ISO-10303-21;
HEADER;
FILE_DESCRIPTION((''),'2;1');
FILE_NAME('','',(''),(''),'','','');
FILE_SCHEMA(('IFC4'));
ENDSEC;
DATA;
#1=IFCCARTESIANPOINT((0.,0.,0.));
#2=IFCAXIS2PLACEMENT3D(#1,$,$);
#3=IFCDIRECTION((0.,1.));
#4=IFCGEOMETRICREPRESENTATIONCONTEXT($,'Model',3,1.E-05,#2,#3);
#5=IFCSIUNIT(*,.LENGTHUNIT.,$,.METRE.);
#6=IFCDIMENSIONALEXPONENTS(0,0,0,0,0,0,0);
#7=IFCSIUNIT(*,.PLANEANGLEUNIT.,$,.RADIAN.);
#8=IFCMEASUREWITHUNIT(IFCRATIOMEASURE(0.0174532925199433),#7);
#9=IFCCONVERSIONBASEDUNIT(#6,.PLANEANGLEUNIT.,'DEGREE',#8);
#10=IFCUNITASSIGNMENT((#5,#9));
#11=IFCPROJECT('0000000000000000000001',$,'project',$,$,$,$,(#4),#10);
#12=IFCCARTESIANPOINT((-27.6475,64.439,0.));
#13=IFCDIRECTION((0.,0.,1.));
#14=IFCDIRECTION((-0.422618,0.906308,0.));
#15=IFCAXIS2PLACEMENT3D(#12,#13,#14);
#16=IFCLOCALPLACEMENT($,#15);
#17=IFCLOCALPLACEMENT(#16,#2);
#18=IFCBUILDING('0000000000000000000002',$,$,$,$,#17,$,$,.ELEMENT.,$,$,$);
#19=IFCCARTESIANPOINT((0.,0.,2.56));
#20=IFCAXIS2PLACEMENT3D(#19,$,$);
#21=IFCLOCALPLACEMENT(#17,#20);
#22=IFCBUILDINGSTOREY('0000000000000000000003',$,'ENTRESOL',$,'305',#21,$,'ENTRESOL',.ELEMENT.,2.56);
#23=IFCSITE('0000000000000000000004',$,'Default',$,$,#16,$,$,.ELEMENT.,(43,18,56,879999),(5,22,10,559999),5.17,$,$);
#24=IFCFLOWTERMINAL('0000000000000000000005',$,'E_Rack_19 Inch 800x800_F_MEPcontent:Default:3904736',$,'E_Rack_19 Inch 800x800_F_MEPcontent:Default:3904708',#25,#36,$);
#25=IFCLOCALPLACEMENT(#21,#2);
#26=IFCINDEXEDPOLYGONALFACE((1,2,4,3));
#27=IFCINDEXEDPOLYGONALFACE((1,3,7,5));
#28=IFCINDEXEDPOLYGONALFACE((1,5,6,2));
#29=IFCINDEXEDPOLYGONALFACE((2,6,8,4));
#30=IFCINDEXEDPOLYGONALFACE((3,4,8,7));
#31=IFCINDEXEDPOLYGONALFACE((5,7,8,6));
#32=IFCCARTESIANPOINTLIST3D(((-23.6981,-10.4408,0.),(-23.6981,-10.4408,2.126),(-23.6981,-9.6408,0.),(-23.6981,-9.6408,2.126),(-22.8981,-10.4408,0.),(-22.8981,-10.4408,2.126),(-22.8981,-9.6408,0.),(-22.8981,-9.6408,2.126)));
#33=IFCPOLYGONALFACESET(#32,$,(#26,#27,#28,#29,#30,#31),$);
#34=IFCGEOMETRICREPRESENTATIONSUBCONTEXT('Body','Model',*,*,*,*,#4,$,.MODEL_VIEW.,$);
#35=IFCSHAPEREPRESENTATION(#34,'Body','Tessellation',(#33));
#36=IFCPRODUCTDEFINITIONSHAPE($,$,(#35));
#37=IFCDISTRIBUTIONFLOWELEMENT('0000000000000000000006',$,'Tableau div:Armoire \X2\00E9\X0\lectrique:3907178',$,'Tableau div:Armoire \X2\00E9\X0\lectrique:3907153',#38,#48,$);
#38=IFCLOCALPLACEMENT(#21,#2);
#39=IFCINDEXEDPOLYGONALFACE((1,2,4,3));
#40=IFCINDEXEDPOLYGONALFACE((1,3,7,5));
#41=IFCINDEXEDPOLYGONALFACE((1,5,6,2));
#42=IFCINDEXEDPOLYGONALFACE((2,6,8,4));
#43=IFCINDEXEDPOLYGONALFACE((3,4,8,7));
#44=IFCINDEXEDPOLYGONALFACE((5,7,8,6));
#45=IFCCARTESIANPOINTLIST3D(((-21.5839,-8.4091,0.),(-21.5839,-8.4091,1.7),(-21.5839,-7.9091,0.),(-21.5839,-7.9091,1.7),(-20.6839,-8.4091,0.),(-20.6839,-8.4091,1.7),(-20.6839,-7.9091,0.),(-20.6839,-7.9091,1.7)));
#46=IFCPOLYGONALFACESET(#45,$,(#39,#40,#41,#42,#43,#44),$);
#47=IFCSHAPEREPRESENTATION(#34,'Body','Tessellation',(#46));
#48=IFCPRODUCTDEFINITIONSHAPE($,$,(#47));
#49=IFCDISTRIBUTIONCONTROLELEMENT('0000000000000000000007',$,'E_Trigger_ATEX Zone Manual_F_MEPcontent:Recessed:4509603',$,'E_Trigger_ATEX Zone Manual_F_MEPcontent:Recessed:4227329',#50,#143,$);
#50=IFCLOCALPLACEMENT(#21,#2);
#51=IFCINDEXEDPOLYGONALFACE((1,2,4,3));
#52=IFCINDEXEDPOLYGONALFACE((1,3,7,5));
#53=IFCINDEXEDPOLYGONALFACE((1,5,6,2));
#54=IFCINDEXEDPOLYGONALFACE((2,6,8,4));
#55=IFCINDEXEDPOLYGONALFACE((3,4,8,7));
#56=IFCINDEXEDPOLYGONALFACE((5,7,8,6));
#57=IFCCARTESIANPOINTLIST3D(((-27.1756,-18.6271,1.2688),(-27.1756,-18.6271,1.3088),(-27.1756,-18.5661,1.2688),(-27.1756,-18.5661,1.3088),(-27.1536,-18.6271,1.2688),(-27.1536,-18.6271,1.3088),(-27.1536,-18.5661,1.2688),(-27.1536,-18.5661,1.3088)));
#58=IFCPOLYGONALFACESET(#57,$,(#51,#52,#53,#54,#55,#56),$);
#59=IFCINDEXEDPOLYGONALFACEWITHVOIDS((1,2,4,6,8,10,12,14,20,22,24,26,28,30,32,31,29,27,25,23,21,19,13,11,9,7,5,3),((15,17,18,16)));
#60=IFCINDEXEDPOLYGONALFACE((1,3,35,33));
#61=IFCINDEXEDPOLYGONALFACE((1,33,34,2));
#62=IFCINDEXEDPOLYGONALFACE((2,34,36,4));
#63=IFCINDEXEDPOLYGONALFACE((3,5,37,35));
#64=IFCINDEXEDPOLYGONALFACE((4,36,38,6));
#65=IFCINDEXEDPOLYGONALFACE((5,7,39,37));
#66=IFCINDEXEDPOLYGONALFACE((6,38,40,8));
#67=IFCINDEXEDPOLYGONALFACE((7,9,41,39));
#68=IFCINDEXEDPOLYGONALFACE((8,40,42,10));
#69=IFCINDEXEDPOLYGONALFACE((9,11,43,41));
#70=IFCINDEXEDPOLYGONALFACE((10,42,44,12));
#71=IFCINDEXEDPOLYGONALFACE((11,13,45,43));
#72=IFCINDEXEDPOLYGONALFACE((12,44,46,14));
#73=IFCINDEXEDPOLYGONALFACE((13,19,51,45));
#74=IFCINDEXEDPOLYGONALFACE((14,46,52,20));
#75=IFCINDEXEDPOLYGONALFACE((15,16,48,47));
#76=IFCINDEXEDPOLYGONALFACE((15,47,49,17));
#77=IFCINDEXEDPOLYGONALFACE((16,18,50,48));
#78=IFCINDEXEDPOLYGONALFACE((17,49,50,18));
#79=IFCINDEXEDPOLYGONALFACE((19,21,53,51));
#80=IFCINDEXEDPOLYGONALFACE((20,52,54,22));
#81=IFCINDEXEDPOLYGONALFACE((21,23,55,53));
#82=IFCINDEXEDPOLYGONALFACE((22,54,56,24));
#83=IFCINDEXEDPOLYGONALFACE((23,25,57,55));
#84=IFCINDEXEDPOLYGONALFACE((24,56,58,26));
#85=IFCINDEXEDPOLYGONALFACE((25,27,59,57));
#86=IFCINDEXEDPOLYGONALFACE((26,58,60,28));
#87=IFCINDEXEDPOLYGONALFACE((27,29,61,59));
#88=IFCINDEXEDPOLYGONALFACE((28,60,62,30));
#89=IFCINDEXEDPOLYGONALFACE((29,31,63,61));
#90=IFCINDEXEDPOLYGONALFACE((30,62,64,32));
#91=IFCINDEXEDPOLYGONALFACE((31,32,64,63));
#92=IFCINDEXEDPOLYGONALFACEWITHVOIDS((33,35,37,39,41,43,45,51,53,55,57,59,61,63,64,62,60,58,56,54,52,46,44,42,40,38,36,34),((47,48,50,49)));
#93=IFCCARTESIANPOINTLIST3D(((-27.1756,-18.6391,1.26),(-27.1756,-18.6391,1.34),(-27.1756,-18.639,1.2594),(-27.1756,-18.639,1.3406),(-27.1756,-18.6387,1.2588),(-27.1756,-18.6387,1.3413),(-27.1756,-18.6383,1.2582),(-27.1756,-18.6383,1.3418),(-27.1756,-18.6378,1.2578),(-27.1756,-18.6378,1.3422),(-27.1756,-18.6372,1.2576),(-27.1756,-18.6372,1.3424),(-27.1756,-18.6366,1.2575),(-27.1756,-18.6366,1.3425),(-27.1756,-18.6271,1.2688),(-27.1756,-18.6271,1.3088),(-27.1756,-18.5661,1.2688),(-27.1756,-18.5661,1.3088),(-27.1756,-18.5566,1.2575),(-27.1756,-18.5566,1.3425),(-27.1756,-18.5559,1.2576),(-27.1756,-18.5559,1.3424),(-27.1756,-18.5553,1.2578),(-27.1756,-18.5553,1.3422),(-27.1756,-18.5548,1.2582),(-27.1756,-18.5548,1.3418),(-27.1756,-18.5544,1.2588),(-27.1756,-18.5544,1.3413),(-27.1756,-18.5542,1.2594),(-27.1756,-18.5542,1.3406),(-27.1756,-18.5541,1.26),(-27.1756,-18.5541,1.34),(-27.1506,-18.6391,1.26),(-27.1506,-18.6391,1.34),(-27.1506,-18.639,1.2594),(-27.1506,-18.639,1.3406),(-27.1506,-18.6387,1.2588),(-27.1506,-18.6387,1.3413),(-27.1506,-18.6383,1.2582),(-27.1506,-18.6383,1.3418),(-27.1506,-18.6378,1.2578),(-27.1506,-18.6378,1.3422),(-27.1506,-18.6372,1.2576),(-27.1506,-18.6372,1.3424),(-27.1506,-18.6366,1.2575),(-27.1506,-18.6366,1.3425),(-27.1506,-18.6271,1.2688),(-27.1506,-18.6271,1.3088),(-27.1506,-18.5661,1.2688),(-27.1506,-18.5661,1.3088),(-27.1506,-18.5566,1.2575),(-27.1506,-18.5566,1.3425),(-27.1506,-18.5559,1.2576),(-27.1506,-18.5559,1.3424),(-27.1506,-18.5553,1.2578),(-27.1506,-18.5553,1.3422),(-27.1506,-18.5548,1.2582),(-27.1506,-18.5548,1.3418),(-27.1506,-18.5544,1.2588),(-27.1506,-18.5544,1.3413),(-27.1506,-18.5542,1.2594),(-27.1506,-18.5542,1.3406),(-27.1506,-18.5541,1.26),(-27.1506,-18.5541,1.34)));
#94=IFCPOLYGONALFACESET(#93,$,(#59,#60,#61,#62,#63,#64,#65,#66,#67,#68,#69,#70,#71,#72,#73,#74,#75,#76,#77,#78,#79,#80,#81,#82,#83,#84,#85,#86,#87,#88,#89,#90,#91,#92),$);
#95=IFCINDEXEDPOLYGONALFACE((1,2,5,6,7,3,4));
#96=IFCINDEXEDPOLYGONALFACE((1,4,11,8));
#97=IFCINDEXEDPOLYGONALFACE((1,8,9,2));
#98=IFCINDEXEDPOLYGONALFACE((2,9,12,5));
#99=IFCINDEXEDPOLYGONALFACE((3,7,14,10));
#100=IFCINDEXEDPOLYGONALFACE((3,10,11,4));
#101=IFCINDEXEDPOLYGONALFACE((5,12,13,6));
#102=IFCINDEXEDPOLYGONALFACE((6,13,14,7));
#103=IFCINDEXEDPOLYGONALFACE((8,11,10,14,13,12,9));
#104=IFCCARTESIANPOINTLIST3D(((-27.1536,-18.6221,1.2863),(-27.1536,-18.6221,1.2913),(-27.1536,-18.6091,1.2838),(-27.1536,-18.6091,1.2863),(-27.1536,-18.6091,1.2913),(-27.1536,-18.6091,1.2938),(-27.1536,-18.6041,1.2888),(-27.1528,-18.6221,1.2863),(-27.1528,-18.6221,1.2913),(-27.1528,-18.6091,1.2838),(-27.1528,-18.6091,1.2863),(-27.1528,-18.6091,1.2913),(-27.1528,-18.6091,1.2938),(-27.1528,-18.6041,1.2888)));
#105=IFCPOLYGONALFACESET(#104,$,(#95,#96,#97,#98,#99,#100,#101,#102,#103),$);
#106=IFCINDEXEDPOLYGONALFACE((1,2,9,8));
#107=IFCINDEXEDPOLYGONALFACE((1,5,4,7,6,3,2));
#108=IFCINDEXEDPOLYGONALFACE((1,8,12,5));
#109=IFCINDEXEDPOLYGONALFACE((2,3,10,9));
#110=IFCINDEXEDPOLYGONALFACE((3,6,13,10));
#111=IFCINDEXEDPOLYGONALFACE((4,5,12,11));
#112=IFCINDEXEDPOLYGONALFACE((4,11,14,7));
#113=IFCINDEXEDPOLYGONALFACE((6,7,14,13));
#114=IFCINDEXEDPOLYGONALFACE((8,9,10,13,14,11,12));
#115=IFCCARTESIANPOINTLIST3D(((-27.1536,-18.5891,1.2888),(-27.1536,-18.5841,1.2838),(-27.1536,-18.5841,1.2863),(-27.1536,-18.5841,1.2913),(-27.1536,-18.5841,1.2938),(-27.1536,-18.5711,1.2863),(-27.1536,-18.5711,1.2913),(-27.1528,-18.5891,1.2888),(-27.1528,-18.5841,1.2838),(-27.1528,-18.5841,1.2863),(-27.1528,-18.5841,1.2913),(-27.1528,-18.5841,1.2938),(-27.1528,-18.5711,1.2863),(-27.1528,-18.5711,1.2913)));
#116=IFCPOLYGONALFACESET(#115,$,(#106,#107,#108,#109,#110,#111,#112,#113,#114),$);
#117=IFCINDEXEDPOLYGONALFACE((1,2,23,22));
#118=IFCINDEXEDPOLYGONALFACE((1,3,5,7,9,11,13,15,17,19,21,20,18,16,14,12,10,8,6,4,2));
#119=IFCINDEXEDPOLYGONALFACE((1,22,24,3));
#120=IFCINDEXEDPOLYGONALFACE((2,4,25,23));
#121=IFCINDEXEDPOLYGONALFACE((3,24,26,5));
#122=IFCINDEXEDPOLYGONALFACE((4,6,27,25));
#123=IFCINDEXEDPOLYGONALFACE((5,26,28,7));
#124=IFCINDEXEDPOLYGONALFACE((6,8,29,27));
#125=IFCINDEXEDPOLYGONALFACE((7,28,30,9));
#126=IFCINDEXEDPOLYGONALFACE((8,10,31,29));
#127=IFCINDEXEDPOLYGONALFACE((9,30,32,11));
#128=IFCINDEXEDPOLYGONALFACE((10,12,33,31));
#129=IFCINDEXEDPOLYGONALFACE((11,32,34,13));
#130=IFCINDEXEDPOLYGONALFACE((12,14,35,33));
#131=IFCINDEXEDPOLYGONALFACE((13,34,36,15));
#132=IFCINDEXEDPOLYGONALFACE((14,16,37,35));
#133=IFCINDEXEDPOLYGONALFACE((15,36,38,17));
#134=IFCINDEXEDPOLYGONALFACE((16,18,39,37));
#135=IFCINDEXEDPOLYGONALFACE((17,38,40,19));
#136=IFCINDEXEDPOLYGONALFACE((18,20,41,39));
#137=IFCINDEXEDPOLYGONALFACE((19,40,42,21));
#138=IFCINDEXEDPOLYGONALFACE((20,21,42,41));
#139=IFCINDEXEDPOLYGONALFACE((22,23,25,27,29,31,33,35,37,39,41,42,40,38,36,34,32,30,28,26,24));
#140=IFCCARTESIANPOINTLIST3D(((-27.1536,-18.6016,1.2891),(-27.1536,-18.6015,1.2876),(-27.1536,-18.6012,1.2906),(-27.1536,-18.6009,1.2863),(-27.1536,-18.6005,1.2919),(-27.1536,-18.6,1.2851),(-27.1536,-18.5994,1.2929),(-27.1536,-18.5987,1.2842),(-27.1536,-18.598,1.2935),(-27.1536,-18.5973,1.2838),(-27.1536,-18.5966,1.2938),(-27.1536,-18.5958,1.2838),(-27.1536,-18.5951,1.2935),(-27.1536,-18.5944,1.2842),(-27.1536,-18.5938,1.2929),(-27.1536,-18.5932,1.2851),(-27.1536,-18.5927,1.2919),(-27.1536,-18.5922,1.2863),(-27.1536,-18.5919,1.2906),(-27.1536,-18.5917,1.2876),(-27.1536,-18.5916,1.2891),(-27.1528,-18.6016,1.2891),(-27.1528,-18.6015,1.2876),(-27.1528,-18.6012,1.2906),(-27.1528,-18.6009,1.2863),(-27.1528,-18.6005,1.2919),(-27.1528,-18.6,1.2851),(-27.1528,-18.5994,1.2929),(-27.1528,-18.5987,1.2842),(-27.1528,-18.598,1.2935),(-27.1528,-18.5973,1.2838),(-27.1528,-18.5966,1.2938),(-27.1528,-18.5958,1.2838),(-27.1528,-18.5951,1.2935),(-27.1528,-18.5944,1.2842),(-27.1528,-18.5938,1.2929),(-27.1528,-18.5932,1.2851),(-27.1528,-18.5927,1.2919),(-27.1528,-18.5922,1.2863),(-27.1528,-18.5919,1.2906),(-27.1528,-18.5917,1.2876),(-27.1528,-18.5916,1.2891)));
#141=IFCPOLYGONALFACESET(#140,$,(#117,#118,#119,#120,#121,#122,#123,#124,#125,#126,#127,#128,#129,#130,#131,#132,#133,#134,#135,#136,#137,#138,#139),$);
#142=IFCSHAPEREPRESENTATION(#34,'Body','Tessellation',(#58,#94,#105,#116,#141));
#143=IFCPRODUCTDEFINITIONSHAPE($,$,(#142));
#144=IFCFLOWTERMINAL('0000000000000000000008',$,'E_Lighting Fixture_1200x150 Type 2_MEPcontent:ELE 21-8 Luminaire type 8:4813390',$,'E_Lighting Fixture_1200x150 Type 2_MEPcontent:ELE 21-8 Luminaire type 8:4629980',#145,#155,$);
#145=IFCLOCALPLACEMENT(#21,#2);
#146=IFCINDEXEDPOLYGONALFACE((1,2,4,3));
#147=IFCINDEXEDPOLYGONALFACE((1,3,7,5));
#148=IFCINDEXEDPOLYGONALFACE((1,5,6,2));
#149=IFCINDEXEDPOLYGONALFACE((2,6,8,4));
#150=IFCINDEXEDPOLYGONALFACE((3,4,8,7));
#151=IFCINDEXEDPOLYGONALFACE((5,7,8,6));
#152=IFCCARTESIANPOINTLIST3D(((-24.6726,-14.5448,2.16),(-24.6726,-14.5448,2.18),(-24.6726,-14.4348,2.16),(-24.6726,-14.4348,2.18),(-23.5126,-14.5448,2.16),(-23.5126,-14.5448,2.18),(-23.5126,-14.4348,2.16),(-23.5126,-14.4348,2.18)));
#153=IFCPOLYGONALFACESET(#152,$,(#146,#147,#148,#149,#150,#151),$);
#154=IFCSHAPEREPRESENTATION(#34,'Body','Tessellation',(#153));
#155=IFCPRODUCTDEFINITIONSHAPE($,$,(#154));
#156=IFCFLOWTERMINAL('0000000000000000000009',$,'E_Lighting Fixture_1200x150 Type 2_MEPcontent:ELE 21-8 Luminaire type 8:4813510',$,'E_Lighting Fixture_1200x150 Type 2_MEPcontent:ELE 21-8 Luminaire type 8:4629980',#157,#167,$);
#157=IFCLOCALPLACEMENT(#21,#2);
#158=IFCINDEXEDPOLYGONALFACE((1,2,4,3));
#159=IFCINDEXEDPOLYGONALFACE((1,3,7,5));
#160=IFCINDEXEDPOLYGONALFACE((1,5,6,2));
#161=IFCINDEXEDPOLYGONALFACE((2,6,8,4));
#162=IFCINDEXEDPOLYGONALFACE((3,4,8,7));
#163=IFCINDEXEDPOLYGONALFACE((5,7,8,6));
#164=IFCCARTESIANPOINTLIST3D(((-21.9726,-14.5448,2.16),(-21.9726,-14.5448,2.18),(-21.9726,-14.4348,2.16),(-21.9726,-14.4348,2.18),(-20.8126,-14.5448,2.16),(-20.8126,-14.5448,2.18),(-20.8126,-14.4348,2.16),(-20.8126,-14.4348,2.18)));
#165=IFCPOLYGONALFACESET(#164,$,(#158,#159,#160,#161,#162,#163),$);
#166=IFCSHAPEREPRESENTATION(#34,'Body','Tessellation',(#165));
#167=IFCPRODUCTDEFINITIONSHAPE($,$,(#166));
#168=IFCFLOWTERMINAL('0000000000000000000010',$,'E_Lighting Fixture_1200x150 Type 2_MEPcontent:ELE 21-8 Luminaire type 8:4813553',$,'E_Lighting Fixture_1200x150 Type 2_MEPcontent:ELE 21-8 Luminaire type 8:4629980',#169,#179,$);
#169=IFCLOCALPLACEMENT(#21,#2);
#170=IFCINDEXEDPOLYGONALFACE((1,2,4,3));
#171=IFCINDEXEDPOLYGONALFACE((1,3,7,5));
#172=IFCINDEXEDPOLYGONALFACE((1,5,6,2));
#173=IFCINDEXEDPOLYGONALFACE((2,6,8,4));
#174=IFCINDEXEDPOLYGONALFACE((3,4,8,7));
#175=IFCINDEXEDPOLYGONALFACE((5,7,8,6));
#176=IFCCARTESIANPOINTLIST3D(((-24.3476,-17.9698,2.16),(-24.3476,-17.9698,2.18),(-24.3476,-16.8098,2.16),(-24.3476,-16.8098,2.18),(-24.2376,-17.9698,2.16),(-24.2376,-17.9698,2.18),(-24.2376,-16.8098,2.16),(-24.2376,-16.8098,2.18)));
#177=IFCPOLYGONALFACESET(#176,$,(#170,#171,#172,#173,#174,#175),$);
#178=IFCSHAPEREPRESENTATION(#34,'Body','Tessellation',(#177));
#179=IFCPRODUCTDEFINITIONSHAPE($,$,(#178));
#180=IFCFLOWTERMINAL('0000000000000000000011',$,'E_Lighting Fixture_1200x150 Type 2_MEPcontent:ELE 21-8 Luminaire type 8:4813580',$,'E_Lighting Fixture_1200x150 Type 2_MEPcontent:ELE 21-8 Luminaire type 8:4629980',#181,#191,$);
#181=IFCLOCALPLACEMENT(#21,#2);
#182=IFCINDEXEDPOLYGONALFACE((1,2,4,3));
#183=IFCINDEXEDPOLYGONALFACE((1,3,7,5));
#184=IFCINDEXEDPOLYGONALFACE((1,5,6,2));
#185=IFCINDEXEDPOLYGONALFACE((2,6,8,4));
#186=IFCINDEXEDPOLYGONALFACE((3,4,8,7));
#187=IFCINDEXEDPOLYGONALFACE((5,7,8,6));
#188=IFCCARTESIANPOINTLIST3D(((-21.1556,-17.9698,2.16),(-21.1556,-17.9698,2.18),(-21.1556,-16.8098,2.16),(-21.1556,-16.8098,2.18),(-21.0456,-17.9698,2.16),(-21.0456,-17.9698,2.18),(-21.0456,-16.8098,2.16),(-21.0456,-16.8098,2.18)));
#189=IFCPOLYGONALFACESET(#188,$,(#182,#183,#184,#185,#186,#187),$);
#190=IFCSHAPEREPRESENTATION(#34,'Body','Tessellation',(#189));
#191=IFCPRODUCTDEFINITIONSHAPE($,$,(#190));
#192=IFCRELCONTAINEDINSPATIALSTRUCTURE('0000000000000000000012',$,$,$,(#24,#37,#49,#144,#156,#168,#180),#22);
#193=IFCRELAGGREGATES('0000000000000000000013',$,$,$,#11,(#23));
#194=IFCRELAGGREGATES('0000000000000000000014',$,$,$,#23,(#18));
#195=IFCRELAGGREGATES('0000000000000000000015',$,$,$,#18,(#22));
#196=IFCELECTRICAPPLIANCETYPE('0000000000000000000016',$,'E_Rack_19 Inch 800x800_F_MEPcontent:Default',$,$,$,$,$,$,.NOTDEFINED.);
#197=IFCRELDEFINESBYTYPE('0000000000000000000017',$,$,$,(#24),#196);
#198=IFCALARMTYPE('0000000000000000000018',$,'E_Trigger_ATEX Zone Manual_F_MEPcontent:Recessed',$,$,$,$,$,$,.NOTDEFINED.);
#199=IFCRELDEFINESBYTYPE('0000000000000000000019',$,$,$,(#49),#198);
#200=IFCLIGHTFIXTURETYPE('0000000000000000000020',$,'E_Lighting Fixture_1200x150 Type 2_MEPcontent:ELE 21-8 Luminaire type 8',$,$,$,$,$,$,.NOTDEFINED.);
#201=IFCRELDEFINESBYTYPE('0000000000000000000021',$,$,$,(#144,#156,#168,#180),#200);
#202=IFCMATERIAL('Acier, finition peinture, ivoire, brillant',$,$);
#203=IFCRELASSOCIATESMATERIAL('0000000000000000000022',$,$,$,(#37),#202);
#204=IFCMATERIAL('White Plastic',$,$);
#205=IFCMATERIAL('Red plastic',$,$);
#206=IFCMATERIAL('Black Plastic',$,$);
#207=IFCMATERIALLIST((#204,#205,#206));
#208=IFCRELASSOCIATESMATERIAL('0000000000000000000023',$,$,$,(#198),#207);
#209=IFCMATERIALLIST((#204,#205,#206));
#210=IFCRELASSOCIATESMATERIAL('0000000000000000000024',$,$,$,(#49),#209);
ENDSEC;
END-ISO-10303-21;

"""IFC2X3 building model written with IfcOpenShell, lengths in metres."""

from ifc_helpers import new_model, entity, si_unit, converted_unit, direction, frame, frame_2d, origin, origin_2d_with_axis, place, context, subcontext, project, spatial, polyline, circle_curve, parameter, trimmed, segment, composite_curve, rectangle, circle, outline, extrude, source, transform, mapped, material, material_list, type_object, type_shapes, element, save


model = new_model("IFC2X3")

# Units and contexts
model_context = context("Model", 3, precision=1e-05, world=origin(), true_north=direction((0.0, 1.0)))
body_context = subcontext(model_context, "Body", "Model", "MODEL_VIEW")
ifc_project = project(units=[si_unit("LENGTHUNIT", "METRE"), converted_unit("PLANEANGLEUNIT", "DEGREE", entity("IfcRatioMeasure", 0.0174532925199433), si_unit("PLANEANGLEUNIT", "RADIAN"), dimensions=[0, 0, 0, 0, 0, 0, 0])], contexts=[model_context])

# Site, building, storey
site_placement = place(None, frame((-27.6475, 64.439, 0.0), z_axis=(0.0, 0.0, 1.0), x_axis=(-0.422618, 0.906308, 0.0)))
site = spatial("IfcSite", under=ifc_project, at=site_placement, Name="Default", CompositionType="ELEMENT", RefLatitude=(43, 18, 56, 879999), RefLongitude=(5, 22, 10, 559999), RefElevation=5.17)
building_placement = place(site_placement, origin())
building = spatial("IfcBuilding", under=site, at=building_placement, CompositionType="ELEMENT")
storey_placement = place(building_placement, frame((0.0, 0.0, 2.56)))
storey = spatial("IfcBuildingStorey", under=building, at=storey_placement, Name="ENTRESOL", ObjectType="305", LongName="ENTRESOL", CompositionType="ELEMENT", Elevation=2.56)

# Flow terminal
electric_appliance_type = type_object("IfcElectricApplianceType", Name="E_Rack_19 Inch 800x800_F_MEPcontent:Default", PredefinedType="NOTDEFINED")
shared_shape_1 = source(origin(), body_context, "Body", "SweptSolid", [
    extrude(rectangle(XDim=0.8, YDim=2.126, at=origin_2d_with_axis()), frame((0.0, 1.063, 0.0)), (0.0, 0.0, 1.0), 0.8),
])
type_shapes(electric_appliance_type, [shared_shape_1])
flow_terminal_1_placement = place(storey_placement, frame((-23.6981, -10.0408, 0.0), z_axis=(1.0, 0.0, 0.0), x_axis=(0.0, 1.0, 0.0)))
element("IfcFlowTerminal", 1, at=flow_terminal_1_placement, inside=storey, type_object=electric_appliance_type, Name="E_Rack_19 Inch 800x800_F_MEPcontent:Default:3904736", ObjectType="E_Rack_19 Inch 800x800_F_MEPcontent:Default:3904708", context=body_context, shape_type="MappedRepresentation", body=[
    mapped(shared_shape_1, transform((0.0, 0.0, 0.0), scale=1.0)),
])

# Distribution flow element
ifc_material_1 = material(Name="Acier, finition peinture, ivoire, brillant")
shared_shape_2 = source(origin(), body_context, "Body", "SweptSolid", [
    extrude(rectangle(XDim=0.9, YDim=0.5, at=origin_2d_with_axis()), frame((0.0, -0.45, 0.0), z_axis=(0.0, 0.0, 1.0), x_axis=(0.0, 1.0, 0.0)), (0.0, 0.0, 1.0), 1.7),
])
distribution_flow_element_placement = place(storey_placement, frame((-20.6839, -8.1591, 0.0), z_axis=(0.0, 0.0, 1.0), x_axis=(0.0, -1.0, 0.0)))
element("IfcDistributionFlowElement", 2, at=distribution_flow_element_placement, inside=storey, material=ifc_material_1, Name="Tableau div:Armoire électrique:3907178", ObjectType="Tableau div:Armoire électrique:3907153", context=body_context, shape_type="MappedRepresentation", body=[
    mapped(shared_shape_2, transform((0.0, 0.0, 0.0), scale=1.0)),
])

# Distribution control element
ifc_material_2 = material(Name="White Plastic")
ifc_material_3 = material(Name="Red plastic")
ifc_material_4 = material(Name="Black Plastic")
ifc_material_list_1 = material_list([ifc_material_2, ifc_material_3, ifc_material_4])
ifc_material_list_2 = material_list([ifc_material_2, ifc_material_3, ifc_material_4])
alarm_type = type_object("IfcAlarmType", Name="E_Trigger_ATEX Zone Manual_F_MEPcontent:Recessed", PredefinedType="NOTDEFINED", material=ifc_material_list_2)
shared_shape_3 = source(origin(), body_context, "Body", "SweptSolid", [
    extrude(rectangle(XDim=0.061, YDim=0.04, at=origin_2d_with_axis()), frame((0.0, -0.0112, 0.0), z_axis=(0.0, 0.0, 1.0), x_axis=(-1.0, 0.0, 0.0)), (0.0, 0.0, 1.0), 0.022),
    extrude(outline(composite_curve([segment(polyline([(-0.04, -0.0425), (0.04, -0.0425)]), True, "CONTINUOUS"), segment(trimmed(circle_curve(frame_2d((0.04, -0.04), x_axis=(-1.0, 0.0)), 0.0025), [parameter(90.0)], [parameter(180.0)], True, "PARAMETER"), True, "CONTINUOUS"), segment(polyline([(0.0425, -0.04), (0.0425, 0.04)]), True, "CONTINUOUS"), segment(trimmed(circle_curve(frame_2d((0.04, 0.04), x_axis=(-1.0, 0.0)), 0.0025), [parameter(180.0)], [parameter(270.0)], True, "PARAMETER"), True, "CONTINUOUS"), segment(polyline([(0.04, 0.0425), (-0.04, 0.0425)]), True, "CONTINUOUS"), segment(trimmed(circle_curve(frame_2d((-0.04, 0.04), x_axis=(-1.0, 0.0)), 0.0025), [parameter(270.0)], [parameter(0.0)], True, "PARAMETER"), True, "CONTINUOUS"), segment(polyline([(-0.0425, 0.04), (-0.0425, -0.04)]), True, "CONTINUOUS"), segment(trimmed(circle_curve(frame_2d((-0.04, -0.04), x_axis=(-1.0, 0.0)), 0.0025), [parameter(360.0)], [parameter(90.0)], True, "PARAMETER"), True, "CONTINUOUS")], self_intersect=False), holes=[polyline([(-0.0305, -0.0088), (-0.0305, 0.0312), (0.0305, 0.0312), (0.0305, -0.0088), (-0.0305, -0.0088)])]), frame((0.0, 0.0, 0.0), z_axis=(0.0, 0.0, 1.0), x_axis=(-1.0, 0.0, 0.0)), (0.0, 0.0, 1.0), 0.025),
    extrude(outline(polyline([(-0.01, 0.0025), (-0.01, -0.0025), (0.003, -0.0025), (0.003, -0.005), (0.008, 0.0), (0.003, 0.005), (0.003, 0.0025), (-0.01, 0.0025)])), frame((-0.0155, -0.0112, 0.022), z_axis=(0.0, 0.0, -1.0), x_axis=(1.0, 0.0, 0.0)), (0.0, 0.0, -1.0), 0.0008),
    extrude(outline(polyline([(-0.0014, -0.0057), (0.0057, -0.0057), (0.0057, 0.0014), (0.0039, -0.0004), (-0.0053, 0.0088), (-0.0088, 0.0053), (0.0004, -0.0039), (-0.0014, -0.0057)])), frame((0.0155, -0.0112, 0.022), z_axis=(0.0, 0.0, 1.0), x_axis=(-0.707107, -0.707107, 0.0)), (0.0, 0.0, 1.0), 0.0008),
    extrude(circle(Radius=0.005, at=frame_2d((0.0, 0.0), x_axis=(1.0, 0.0))), frame((0.0, -0.0112, 0.022), z_axis=(0.0, 0.0, 1.0), x_axis=(0.0, 1.0, 0.0)), (0.0, 0.0, 1.0), 0.0008),
])
type_shapes(alarm_type, [shared_shape_3])
distribution_control_element_placement = place(storey_placement, frame((-27.1756, -18.5966, 1.3), z_axis=(1.0, 0.0, 0.0), x_axis=(0.0, 1.0, 0.0)))
element("IfcDistributionControlElement", 3, at=distribution_control_element_placement, inside=storey, type_object=alarm_type, material=ifc_material_list_1, Name="E_Trigger_ATEX Zone Manual_F_MEPcontent:Recessed:4509603", ObjectType="E_Trigger_ATEX Zone Manual_F_MEPcontent:Recessed:4227329", context=body_context, shape_type="MappedRepresentation", body=[
    mapped(shared_shape_3, transform((0.0, 0.0, 0.0), scale=1.0)),
])

# Flow terminals
light_fixture_type_1 = type_object("IfcLightFixtureType", Name="E_Lighting Fixture_1200x150 Type 2_MEPcontent:ELE 21-8 Luminaire type 8", PredefinedType="NOTDEFINED")
shared_shape_4 = source(origin(), body_context, "Body", "SweptSolid", [
    extrude(rectangle(XDim=0.11, YDim=1.16, at=origin_2d_with_axis()), frame((0.0, 0.0, 0.0), z_axis=(0.0, 0.0, 1.0), x_axis=(0.0, -1.0, 0.0)), (0.0, 0.0, 1.0), 0.02),
])
type_shapes(light_fixture_type_1, [shared_shape_4])
for number, where, z_axis, x_axis, name in (
    (4, (-24.0926, -14.4898, 2.16), (0.0, 0.0, 1.0), (-1.0, 0.0, 0.0), "E_Lighting Fixture_1200x150 Type 2_MEPcontent:ELE 21-8 Luminaire type 8:4813390"),
    (5, (-21.3926, -14.4898, 2.16), (0.0, 0.0, 1.0), (-1.0, 0.0, 0.0), "E_Lighting Fixture_1200x150 Type 2_MEPcontent:ELE 21-8 Luminaire type 8:4813510"),
    (6, (-24.2926, -17.3898, 2.16), (0.0, 0.0, 1.0), (0.0, -1.0, 0.0), "E_Lighting Fixture_1200x150 Type 2_MEPcontent:ELE 21-8 Luminaire type 8:4813553"),
    (7, (-21.1006, -17.3898, 2.16), (0.0, 0.0, 1.0), (0.0, -1.0, 0.0), "E_Lighting Fixture_1200x150 Type 2_MEPcontent:ELE 21-8 Luminaire type 8:4813580"),
):
    element("IfcFlowTerminal", number, at=place(storey_placement, frame(where, z_axis=z_axis, x_axis=x_axis)), inside=storey, type_object=light_fixture_type_1, Name=name, ObjectType="E_Lighting Fixture_1200x150 Type 2_MEPcontent:ELE 21-8 Luminaire type 8:4629980", context=body_context, shape_type="MappedRepresentation", body=[
        mapped(shared_shape_4, transform((0.0, 0.0, 0.0), scale=1.0)),
    ])

save(model, "model.ifc")
